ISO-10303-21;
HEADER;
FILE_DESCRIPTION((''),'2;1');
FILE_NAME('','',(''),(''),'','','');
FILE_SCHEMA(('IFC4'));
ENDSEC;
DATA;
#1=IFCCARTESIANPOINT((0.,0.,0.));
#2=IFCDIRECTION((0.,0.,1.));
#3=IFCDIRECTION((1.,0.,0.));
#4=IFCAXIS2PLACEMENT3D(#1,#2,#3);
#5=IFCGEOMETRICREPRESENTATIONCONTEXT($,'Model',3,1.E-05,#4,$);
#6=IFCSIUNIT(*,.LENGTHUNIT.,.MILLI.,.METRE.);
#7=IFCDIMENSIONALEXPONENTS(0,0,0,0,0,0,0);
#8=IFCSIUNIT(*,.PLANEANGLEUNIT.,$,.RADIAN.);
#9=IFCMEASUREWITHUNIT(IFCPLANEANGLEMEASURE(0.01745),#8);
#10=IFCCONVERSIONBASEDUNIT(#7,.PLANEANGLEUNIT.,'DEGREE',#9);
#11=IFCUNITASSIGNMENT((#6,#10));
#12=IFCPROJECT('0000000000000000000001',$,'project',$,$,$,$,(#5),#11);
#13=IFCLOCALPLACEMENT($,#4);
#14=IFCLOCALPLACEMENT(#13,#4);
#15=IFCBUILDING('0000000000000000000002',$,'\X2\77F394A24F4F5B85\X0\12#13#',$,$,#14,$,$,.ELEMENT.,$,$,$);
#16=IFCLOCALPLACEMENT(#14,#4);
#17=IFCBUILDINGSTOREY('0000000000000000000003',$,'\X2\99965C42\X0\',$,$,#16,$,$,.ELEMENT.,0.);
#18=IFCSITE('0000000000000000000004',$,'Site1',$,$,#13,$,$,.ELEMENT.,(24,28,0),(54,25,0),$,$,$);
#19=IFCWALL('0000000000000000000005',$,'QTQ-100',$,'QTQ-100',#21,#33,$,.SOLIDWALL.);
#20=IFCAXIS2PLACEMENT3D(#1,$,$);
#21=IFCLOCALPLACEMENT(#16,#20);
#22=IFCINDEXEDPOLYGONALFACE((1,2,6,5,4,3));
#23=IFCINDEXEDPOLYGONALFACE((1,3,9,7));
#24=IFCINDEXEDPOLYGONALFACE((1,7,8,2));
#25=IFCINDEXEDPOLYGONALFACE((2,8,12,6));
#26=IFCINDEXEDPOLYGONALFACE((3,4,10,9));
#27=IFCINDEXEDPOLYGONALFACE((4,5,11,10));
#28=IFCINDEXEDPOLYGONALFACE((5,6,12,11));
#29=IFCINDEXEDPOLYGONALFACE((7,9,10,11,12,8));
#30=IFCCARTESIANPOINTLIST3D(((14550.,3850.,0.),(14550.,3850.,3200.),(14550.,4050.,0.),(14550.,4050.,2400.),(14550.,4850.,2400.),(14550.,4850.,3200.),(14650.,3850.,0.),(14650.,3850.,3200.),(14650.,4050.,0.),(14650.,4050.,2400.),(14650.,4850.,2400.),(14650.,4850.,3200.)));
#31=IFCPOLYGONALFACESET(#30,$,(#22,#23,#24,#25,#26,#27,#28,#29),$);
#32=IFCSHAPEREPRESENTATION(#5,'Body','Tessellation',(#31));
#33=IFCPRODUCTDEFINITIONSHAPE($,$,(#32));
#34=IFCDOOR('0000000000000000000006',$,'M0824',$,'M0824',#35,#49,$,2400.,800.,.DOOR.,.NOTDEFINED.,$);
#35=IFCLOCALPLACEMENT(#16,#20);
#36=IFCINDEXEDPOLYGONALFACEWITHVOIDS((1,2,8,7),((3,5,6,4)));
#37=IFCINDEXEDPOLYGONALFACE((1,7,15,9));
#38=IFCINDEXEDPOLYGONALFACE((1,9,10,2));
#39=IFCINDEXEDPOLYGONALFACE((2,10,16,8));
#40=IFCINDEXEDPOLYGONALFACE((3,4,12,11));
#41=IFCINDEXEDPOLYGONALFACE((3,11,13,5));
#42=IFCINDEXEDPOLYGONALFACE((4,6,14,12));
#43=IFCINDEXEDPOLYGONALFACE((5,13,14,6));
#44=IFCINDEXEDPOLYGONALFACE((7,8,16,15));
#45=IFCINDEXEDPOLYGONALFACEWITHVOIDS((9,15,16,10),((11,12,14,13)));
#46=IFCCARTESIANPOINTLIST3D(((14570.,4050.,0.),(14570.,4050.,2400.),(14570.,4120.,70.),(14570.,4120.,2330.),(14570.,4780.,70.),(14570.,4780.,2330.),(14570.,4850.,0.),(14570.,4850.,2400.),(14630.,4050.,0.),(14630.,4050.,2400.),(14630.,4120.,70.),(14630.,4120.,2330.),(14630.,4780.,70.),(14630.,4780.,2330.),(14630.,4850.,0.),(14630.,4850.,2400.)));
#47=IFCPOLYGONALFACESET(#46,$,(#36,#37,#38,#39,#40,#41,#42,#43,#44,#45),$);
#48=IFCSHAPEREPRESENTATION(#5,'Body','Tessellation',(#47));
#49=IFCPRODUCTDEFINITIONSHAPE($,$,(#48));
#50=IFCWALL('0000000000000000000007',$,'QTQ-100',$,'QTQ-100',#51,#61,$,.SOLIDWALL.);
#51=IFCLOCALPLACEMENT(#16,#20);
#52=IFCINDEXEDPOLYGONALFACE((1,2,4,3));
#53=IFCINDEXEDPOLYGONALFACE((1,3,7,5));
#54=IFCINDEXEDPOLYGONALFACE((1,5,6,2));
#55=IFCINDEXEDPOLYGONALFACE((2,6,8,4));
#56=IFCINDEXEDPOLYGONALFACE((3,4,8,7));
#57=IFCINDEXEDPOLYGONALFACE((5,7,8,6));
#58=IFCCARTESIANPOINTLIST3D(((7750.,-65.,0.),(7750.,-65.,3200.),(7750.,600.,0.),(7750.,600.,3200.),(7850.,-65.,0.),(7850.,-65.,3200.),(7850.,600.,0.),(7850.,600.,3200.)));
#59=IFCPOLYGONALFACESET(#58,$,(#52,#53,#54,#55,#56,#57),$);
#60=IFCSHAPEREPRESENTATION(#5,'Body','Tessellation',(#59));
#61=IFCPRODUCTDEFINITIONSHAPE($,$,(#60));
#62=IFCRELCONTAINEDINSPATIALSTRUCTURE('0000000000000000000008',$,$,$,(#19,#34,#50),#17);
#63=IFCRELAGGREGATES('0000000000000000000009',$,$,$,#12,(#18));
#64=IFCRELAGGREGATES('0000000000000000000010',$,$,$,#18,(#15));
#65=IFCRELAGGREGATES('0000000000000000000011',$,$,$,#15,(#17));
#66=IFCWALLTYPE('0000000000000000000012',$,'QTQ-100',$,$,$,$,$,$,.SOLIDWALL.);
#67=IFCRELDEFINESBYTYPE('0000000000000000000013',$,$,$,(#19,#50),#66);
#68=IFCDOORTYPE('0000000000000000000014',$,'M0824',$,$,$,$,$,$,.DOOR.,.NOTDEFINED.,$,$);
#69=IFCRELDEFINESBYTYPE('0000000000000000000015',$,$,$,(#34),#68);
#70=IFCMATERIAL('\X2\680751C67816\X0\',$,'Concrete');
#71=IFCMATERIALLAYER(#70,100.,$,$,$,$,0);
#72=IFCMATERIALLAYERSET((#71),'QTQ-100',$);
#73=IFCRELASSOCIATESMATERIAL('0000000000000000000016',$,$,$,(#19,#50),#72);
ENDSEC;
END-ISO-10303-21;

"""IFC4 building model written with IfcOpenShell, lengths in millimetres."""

from ifc_helpers import new_model, entity, si_unit, converted_unit, frame, origin_with_axes, place, context, project, spatial, polyline, outline, extrude, material, layer, layer_set, type_object, element, fill, save


model = new_model("IFC4")

# Units and contexts
model_context = context("Model", 3, precision=1e-05, world=origin_with_axes())
ifc_project = project(units=[si_unit("LENGTHUNIT", "METRE", prefix="MILLI"), converted_unit("PLANEANGLEUNIT", "DEGREE", entity("IfcPlaneAngleMeasure", 0.01745), si_unit("PLANEANGLEUNIT", "RADIAN"), dimensions=[0, 0, 0, 0, 0, 0, 0])], contexts=[model_context])

# Site, building, storey
site_placement = place(None, origin_with_axes())
site = spatial("IfcSite", under=ifc_project, at=site_placement, Name="Site1", CompositionType="ELEMENT", RefLatitude=(24, 28, 0), RefLongitude=(54, 25, 0))
building_placement = place(site_placement, origin_with_axes())
building = spatial("IfcBuilding", under=site, at=building_placement, Name="石钢住宅12#13#", CompositionType="ELEMENT")
storey_placement = place(building_placement, origin_with_axes())
storey = spatial("IfcBuildingStorey", under=building, at=storey_placement, Name="首层", CompositionType="ELEMENT", Elevation=0.0)

# Shared definitions
ifc_material = material(Name="标准砖", Category="Concrete")
ifc_layer = layer(ifc_material, 100.0, Priority=0)
ifc_layer_set = layer_set([ifc_layer], Name="QTQ-100")
wall_type = type_object("IfcWallType", Name="QTQ-100", PredefinedType="SOLIDWALL")

# Shared definitions
door_type_1 = type_object("IfcDoorType", Name="M0824", OperationType="NOTDEFINED", PredefinedType="DOOR")

# Wall, opening, door
wall_1_placement = place(storey_placement, origin_with_axes())
wall_1 = element("IfcWall", 1, at=wall_1_placement, inside=storey, type_object=wall_type, material=ifc_layer_set, Name="QTQ-100", ObjectType="QTQ-100", PredefinedType="SOLIDWALL", context=model_context, shape_type="SweptSolid", body=[
    extrude(outline(polyline([(0.0, 0.0), (3200.0, 0.0), (3200.0, 1000.0), (0.0, 1000.0), (0.0, 0.0)])), frame((14550.0, 3850.0, 3200.0), z_axis=(1.0, 0.0, 0.0), x_axis=(0.0, 0.0, -1.0)), (0.0, 0.0, 1.0), 100.0),
])
opening_1_placement = place(storey_placement, origin_with_axes())
opening_1 = element("IfcOpeningElement", 2, at=opening_1_placement, cuts=wall_1, PredefinedType="OPENING", context=model_context, shape_type="SweptSolid", body=[
    extrude(outline(polyline([(0.0, 0.0), (800.0, 0.0), (800.0, 2400.0), (0.0, 2400.0), (0.0, 0.0)])), frame((13550.0, 4050.0, 0.0), z_axis=(1.0, 0.0, 0.0), x_axis=(0.0, 1.0, 0.0)), (0.0, 0.0, 1.0), 2100.0),
])
door_1_placement = place(storey_placement, origin_with_axes())
door_1 = element("IfcDoor", 3, at=door_1_placement, inside=storey, type_object=door_type_1, Name="M0824", ObjectType="M0824", OperationType="NOTDEFINED", OverallHeight=2400.0, OverallWidth=800.0, PredefinedType="DOOR", context=model_context, shape_type="SweptSolid", body=[
    extrude(outline(polyline([(-400.0, -1200.0), (400.0, -1200.0), (400.0, 1200.0), (-400.0, 1200.0), (-400.0, -1200.0)]), holes=[polyline([(-330.0, -1130.0), (-330.0, 1130.0), (330.0, 1130.0), (330.0, -1130.0), (-330.0, -1130.0)])]), frame((14570.0, 4450.0, 1200.0), z_axis=(1.0, 0.0, 0.0), x_axis=(0.0, 1.0, 0.0)), (0.0, 0.0, 1.0), 60.0),
])
fill(opening_1, door_1)

# Wall
wall_2_placement = place(storey_placement, origin_with_axes())
element("IfcWall", 4, at=wall_2_placement, inside=storey, type_object=wall_type, material=ifc_layer_set, Name="QTQ-100", ObjectType="QTQ-100", PredefinedType="SOLIDWALL", context=model_context, shape_type="SweptSolid", body=[
    extrude(outline(polyline([(0.0, 0.0), (3200.0, 0.0), (3200.0, 665.0), (0.0, 665.0), (0.0, 0.0)])), frame((7850.0, 600.0, 3200.0), z_axis=(-1.0, 0.0, 0.0), x_axis=(0.0, 0.0, -1.0)), (0.0, 0.0, 1.0), 100.0),
])

save(model, "model.ifc")
